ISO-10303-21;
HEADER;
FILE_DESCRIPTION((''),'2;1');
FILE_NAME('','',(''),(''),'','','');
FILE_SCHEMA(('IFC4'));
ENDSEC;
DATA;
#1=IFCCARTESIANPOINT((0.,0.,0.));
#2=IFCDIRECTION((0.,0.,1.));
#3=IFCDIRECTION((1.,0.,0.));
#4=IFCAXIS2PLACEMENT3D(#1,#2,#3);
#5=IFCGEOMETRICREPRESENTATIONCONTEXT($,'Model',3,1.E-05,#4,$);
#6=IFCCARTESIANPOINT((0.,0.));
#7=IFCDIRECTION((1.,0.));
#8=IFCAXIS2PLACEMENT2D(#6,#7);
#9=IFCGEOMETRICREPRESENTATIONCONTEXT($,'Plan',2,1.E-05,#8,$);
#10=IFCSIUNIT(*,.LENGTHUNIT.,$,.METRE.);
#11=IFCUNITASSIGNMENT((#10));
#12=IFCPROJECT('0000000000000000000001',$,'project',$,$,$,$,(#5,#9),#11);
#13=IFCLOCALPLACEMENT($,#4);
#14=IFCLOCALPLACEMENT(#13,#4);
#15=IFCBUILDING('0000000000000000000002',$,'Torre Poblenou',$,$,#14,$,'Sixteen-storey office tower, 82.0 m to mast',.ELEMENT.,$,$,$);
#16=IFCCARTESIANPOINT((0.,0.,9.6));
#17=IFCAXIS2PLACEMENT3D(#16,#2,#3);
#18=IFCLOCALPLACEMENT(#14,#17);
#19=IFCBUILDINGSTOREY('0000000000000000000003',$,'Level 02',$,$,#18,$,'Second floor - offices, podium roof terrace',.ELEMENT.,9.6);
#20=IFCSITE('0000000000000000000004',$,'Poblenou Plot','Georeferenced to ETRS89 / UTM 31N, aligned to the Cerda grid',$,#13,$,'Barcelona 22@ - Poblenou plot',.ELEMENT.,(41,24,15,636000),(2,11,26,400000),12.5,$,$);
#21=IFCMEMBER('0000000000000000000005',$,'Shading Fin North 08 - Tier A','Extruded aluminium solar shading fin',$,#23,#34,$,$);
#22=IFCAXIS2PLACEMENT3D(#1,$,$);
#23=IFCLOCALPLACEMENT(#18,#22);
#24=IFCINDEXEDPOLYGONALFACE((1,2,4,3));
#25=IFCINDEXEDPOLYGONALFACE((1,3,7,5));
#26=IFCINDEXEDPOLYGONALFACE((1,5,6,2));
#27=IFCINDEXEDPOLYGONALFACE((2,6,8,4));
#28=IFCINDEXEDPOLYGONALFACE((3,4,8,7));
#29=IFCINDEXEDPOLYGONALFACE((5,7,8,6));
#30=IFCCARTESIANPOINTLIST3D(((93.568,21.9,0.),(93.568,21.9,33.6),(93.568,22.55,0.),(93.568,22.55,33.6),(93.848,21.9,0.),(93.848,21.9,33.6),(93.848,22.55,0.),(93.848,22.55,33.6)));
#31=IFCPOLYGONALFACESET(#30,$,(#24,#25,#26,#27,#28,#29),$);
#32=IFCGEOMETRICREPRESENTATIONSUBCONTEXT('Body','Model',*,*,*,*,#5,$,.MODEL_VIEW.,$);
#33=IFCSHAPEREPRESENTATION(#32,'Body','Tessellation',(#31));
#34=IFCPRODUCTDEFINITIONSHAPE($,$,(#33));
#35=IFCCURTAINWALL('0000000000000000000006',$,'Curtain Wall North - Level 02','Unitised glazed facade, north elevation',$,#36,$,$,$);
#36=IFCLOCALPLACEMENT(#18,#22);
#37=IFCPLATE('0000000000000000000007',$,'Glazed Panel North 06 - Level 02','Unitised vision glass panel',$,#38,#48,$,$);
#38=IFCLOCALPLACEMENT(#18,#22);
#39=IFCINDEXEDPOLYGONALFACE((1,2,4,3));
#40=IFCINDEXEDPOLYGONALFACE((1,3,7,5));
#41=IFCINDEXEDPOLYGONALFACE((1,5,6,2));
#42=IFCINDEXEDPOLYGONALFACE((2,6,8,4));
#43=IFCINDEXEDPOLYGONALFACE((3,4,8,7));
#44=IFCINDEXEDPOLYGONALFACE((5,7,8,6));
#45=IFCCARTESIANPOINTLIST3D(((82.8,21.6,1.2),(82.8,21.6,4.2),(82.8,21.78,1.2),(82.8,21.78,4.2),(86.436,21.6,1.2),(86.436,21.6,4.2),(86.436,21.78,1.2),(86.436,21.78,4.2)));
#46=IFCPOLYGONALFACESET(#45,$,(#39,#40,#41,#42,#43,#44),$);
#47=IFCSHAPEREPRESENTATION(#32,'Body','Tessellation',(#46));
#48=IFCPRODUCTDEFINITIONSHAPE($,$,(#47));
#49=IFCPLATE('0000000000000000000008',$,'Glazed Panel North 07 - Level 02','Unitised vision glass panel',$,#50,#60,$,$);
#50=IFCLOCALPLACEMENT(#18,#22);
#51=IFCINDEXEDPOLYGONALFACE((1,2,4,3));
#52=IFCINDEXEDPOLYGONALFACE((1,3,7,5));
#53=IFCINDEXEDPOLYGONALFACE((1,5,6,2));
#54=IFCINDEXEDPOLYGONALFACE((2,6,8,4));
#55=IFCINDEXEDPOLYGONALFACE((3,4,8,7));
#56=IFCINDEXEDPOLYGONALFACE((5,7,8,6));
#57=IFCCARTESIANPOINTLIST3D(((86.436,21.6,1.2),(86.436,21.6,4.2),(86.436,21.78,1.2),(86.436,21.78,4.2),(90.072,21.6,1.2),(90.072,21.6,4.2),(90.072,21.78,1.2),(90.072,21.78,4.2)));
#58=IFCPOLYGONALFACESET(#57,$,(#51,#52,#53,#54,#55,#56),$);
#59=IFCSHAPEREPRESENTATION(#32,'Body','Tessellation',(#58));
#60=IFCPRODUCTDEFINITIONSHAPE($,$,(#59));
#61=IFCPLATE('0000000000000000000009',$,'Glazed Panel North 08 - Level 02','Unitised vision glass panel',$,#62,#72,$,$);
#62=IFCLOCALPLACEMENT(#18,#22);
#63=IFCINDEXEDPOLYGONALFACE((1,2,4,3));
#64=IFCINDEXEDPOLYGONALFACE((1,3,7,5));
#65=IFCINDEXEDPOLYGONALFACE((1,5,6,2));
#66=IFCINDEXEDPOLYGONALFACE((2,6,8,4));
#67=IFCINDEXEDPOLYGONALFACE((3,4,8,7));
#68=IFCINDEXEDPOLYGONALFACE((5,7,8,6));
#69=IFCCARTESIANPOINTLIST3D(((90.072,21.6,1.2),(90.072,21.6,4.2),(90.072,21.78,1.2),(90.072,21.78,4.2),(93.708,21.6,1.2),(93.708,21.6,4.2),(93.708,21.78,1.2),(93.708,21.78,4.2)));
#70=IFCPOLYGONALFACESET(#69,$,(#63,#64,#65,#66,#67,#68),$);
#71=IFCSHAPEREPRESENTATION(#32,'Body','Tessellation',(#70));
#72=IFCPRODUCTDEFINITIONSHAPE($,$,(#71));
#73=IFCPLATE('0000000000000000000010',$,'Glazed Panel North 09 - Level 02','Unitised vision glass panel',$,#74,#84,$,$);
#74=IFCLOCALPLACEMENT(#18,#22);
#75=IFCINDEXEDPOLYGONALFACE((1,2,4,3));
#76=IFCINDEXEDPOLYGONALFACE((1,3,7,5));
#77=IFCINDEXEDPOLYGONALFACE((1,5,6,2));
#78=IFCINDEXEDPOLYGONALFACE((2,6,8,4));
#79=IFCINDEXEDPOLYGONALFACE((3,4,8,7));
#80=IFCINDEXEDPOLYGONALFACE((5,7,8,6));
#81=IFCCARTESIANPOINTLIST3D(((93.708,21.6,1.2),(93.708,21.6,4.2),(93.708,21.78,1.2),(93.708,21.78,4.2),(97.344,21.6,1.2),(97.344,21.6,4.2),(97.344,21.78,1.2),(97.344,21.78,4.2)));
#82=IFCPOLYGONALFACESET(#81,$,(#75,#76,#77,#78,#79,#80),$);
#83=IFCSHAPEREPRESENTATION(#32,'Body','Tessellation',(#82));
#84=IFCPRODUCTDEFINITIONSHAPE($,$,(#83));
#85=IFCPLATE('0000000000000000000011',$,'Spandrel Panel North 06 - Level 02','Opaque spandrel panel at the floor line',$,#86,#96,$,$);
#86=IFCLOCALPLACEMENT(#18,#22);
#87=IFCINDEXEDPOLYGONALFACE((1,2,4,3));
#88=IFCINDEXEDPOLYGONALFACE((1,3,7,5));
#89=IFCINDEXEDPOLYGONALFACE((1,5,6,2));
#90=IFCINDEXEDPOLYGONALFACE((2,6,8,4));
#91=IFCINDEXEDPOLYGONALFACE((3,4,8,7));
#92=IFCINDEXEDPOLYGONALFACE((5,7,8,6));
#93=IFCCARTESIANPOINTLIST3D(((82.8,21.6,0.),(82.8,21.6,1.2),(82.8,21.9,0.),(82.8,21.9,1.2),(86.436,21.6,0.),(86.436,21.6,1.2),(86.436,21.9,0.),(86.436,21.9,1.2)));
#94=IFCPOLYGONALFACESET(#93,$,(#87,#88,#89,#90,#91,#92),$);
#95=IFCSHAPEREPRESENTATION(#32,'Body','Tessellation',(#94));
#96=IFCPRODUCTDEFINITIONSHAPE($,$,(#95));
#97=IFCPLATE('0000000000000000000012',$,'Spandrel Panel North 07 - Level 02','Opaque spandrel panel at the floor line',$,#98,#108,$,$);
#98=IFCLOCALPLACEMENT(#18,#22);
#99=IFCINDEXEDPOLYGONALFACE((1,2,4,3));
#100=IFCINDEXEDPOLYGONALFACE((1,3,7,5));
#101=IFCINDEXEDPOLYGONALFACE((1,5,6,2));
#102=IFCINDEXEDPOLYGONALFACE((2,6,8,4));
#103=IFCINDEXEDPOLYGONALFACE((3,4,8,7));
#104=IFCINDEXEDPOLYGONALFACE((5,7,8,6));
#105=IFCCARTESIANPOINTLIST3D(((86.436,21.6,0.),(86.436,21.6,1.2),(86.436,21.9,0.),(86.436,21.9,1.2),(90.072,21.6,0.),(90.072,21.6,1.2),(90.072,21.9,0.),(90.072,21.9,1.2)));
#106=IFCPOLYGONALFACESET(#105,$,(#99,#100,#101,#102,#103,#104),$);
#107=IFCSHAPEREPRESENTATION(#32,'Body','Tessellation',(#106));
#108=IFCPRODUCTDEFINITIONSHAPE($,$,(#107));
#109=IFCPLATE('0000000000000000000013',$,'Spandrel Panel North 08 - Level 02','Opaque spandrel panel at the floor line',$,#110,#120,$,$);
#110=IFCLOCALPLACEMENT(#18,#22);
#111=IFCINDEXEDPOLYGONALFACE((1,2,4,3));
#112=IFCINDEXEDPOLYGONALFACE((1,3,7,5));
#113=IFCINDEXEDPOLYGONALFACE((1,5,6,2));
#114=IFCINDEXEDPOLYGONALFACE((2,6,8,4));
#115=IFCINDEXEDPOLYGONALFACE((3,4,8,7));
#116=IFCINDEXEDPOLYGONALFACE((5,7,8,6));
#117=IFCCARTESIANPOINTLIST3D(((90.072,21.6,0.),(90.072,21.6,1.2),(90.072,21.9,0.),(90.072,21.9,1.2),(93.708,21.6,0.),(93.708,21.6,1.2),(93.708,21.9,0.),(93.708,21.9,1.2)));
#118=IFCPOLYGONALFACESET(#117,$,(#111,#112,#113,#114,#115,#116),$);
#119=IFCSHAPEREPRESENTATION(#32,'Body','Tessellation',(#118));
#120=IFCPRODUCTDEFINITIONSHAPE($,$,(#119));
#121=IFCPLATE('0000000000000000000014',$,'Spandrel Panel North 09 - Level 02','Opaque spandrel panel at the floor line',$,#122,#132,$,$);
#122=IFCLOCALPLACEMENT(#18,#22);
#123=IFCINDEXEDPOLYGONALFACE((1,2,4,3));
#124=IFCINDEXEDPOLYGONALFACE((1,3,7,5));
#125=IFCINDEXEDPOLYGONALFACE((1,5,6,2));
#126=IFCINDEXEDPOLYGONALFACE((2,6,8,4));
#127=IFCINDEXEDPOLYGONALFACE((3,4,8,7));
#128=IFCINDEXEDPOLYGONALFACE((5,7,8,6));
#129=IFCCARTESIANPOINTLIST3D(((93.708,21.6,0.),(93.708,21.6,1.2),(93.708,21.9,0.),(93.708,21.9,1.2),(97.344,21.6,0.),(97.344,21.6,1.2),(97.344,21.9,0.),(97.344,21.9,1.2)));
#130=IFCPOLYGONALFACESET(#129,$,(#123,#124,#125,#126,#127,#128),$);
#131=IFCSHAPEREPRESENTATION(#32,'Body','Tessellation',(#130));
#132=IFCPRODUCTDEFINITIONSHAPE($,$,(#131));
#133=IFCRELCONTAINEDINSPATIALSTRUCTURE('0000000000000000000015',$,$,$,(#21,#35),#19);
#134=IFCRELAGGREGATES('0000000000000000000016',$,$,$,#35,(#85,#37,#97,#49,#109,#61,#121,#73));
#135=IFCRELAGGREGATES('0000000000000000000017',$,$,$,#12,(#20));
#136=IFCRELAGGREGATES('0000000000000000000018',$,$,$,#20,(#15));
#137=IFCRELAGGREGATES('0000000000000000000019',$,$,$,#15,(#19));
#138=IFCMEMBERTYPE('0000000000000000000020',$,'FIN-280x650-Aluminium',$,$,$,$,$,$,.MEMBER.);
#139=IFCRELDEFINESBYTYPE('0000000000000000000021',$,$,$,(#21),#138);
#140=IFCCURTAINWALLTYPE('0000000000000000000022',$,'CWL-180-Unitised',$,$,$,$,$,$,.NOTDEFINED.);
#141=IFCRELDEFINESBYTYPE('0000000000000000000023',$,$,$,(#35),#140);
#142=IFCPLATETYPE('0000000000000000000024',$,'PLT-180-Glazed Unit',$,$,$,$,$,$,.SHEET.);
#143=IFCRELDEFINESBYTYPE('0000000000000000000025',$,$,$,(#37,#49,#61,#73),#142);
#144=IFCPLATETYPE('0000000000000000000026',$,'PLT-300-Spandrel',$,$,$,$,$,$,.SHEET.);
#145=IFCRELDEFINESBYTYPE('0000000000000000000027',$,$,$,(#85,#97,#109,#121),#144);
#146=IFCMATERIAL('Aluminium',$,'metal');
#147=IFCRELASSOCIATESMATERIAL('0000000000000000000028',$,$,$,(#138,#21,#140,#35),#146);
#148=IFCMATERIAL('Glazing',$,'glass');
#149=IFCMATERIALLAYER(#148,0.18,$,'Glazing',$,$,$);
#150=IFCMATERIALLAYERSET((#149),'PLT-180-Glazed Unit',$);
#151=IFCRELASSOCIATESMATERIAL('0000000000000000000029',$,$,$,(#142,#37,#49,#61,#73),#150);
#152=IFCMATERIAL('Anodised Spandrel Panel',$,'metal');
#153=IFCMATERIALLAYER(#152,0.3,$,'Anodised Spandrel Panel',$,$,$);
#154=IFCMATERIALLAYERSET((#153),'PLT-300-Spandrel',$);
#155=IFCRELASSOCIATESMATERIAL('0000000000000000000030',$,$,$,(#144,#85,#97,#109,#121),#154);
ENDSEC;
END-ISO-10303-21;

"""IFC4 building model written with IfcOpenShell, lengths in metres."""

from ifc_helpers import new_model, si_unit, frame, origin_with_axes, origin_2d_with_axis, place, context, subcontext, project, spatial, line, indexed_curve, rectangle, outline, extrude, material, layer, layer_set, layer_usage, material_profile, profile_set, profile_usage, type_object, element, aggregate, save


model = new_model("IFC4")

# Units and contexts
model_context = context("Model", 3, precision=1e-05, world=origin_with_axes())
plan_context = context("Plan", 2, precision=1e-05, world=origin_2d_with_axis())
body_context = subcontext(model_context, "Body", "Model", "MODEL_VIEW")
ifc_project = project(units=[si_unit("LENGTHUNIT", "METRE")], contexts=[model_context, plan_context])

# Site, building, storey
site_placement = place(None, origin_with_axes())
site = spatial("IfcSite", under=ifc_project, at=site_placement, Name="Poblenou Plot", Description="Georeferenced to ETRS89 / UTM 31N, aligned to the Cerda grid", LongName="Barcelona 22@ - Poblenou plot", CompositionType="ELEMENT", RefLatitude=(41, 24, 15, 636000), RefLongitude=(2, 11, 26, 400000), RefElevation=12.5)
building_placement = place(site_placement, origin_with_axes())
building = spatial("IfcBuilding", under=site, at=building_placement, Name="Torre Poblenou", LongName="Sixteen-storey office tower, 82.0 m to mast", CompositionType="ELEMENT")
storey_placement = place(building_placement, frame((0.0, 0.0, 9.6), z_axis=(0.0, 0.0, 1.0), x_axis=(1.0, 0.0, 0.0)))
storey = spatial("IfcBuildingStorey", under=building, at=storey_placement, Name="Level 02", LongName="Second floor - offices, podium roof terrace", CompositionType="ELEMENT", Elevation=9.6)

# Member
ifc_material_1 = material(Name="Aluminium", Category="metal")
ifc_material_profile_1 = material_profile(ifc_material_1, rectangle(XDim=0.28, YDim=0.65))
ifc_profile_set_1 = profile_set([ifc_material_profile_1], Name="FIN-280x650-Aluminium")
member_type = type_object("IfcMemberType", Name="FIN-280x650-Aluminium", PredefinedType="MEMBER", material=ifc_profile_set_1)
ifc_profile_usage_1 = profile_usage(ifc_profile_set_1)
member_1_placement = place(storey_placement, frame((93.568, 21.9, 0.0), z_axis=(0.0, 0.0, 1.0), x_axis=(1.0, 0.0, 0.0)))
element("IfcMember", 1, at=member_1_placement, inside=storey, type_object=member_type, material=ifc_profile_usage_1, Name="Shading Fin North 08 - Tier A", Description="Extruded aluminium solar shading fin", context=body_context, shape_type="SweptSolid", body=[
    extrude(outline(indexed_curve([(0.0, 0.0), (0.28, 0.0), (0.28, 0.65), (0.0, 0.65)], segments=[line(1, 2, 3, 4, 1)])), origin_with_axes(), (0.0, 0.0, 1.0), 33.6),
])

# Curtain wall, plates
curtain_wall_type = type_object("IfcCurtainWallType", Name="CWL-180-Unitised", PredefinedType="NOTDEFINED", material=ifc_material_1)
curtain_wall_placement = place(storey_placement, frame((64.62, 21.6, 0.0), z_axis=(0.0, 0.0, 1.0), x_axis=(1.0, 0.0, 0.0)))
curtain_wall = element("IfcCurtainWall", 2, at=curtain_wall_placement, inside=storey, type_object=curtain_wall_type, material=ifc_material_1, Name="Curtain Wall North - Level 02", Description="Unitised glazed facade, north elevation")
ifc_material_2 = material(Name="Glazing", Category="glass")
ifc_layer_1 = layer(ifc_material_2, 0.18, Name="Glazing")
ifc_layer_set_1 = layer_set([ifc_layer_1], Name="PLT-180-Glazed Unit")
ifc_layer_usage_1 = layer_usage(ifc_layer_set_1, "AXIS2", "POSITIVE", 0.0)
plate_type_1 = type_object("IfcPlateType", Name="PLT-180-Glazed Unit", PredefinedType="SHEET", material=ifc_layer_set_1)
plate_1_placement = place(curtain_wall_placement, frame((18.18, 0.0, 1.2), z_axis=(0.0, 0.0, 1.0), x_axis=(1.0, 0.0, 0.0)))
plate_1 = element("IfcPlate", 3, at=plate_1_placement, type_object=plate_type_1, material=ifc_layer_usage_1, Name="Glazed Panel North 06 - Level 02", Description="Unitised vision glass panel", context=body_context, shape_type="SweptSolid", body=[
    extrude(outline(indexed_curve([(0.0, 0.0), (3.636, 0.0), (3.636, 0.18), (0.0, 0.18)], segments=[line(1, 2, 3, 4, 1)])), origin_with_axes(), (0.0, 0.0, 1.0), 3.0),
])
ifc_layer_usage_2 = layer_usage(ifc_layer_set_1, "AXIS2", "POSITIVE", 0.0)
plate_2_placement = place(curtain_wall_placement, frame((21.816, 0.0, 1.2), z_axis=(0.0, 0.0, 1.0), x_axis=(1.0, 0.0, 0.0)))
plate_2 = element("IfcPlate", 4, at=plate_2_placement, type_object=plate_type_1, material=ifc_layer_usage_2, Name="Glazed Panel North 07 - Level 02", Description="Unitised vision glass panel", context=body_context, shape_type="SweptSolid", body=[
    extrude(outline(indexed_curve([(0.0, 0.0), (3.636, 0.0), (3.636, 0.18), (0.0, 0.18)], segments=[line(1, 2, 3, 4, 1)])), origin_with_axes(), (0.0, 0.0, 1.0), 3.0),
])
ifc_layer_usage_3 = layer_usage(ifc_layer_set_1, "AXIS2", "POSITIVE", 0.0)
plate_3_placement = place(curtain_wall_placement, frame((25.452, 0.0, 1.2), z_axis=(0.0, 0.0, 1.0), x_axis=(1.0, 0.0, 0.0)))
plate_3 = element("IfcPlate", 5, at=plate_3_placement, type_object=plate_type_1, material=ifc_layer_usage_3, Name="Glazed Panel North 08 - Level 02", Description="Unitised vision glass panel", context=body_context, shape_type="SweptSolid", body=[
    extrude(outline(indexed_curve([(0.0, 0.0), (3.636, 0.0), (3.636, 0.18), (0.0, 0.18)], segments=[line(1, 2, 3, 4, 1)])), origin_with_axes(), (0.0, 0.0, 1.0), 3.0),
])
ifc_layer_usage_4 = layer_usage(ifc_layer_set_1, "AXIS2", "POSITIVE", 0.0)
plate_4_placement = place(curtain_wall_placement, frame((29.088, 0.0, 1.2), z_axis=(0.0, 0.0, 1.0), x_axis=(1.0, 0.0, 0.0)))
plate_4 = element("IfcPlate", 6, at=plate_4_placement, type_object=plate_type_1, material=ifc_layer_usage_4, Name="Glazed Panel North 09 - Level 02", Description="Unitised vision glass panel", context=body_context, shape_type="SweptSolid", body=[
    extrude(outline(indexed_curve([(0.0, 0.0), (3.636, 0.0), (3.636, 0.18), (0.0, 0.18)], segments=[line(1, 2, 3, 4, 1)])), origin_with_axes(), (0.0, 0.0, 1.0), 3.0),
])
ifc_material_3 = material(Name="Anodised Spandrel Panel", Category="metal")
ifc_layer_2 = layer(ifc_material_3, 0.3, Name="Anodised Spandrel Panel")
ifc_layer_set_2 = layer_set([ifc_layer_2], Name="PLT-300-Spandrel")
ifc_layer_usage_5 = layer_usage(ifc_layer_set_2, "AXIS2", "POSITIVE", 0.0)
plate_type_2 = type_object("IfcPlateType", Name="PLT-300-Spandrel", PredefinedType="SHEET", material=ifc_layer_set_2)
plate_5_placement = place(curtain_wall_placement, frame((18.18, 0.0, 0.0), z_axis=(0.0, 0.0, 1.0), x_axis=(1.0, 0.0, 0.0)))
plate_5 = element("IfcPlate", 7, at=plate_5_placement, type_object=plate_type_2, material=ifc_layer_usage_5, Name="Spandrel Panel North 06 - Level 02", Description="Opaque spandrel panel at the floor line", context=body_context, shape_type="SweptSolid", body=[
    extrude(outline(indexed_curve([(0.0, 0.0), (3.636, 0.0), (3.636, 0.3), (0.0, 0.3)], segments=[line(1, 2, 3, 4, 1)])), origin_with_axes(), (0.0, 0.0, 1.0), 1.2),
])
ifc_layer_usage_6 = layer_usage(ifc_layer_set_2, "AXIS2", "POSITIVE", 0.0)
plate_6_placement = place(curtain_wall_placement, frame((21.816, 0.0, 0.0), z_axis=(0.0, 0.0, 1.0), x_axis=(1.0, 0.0, 0.0)))
plate_6 = element("IfcPlate", 8, at=plate_6_placement, type_object=plate_type_2, material=ifc_layer_usage_6, Name="Spandrel Panel North 07 - Level 02", Description="Opaque spandrel panel at the floor line", context=body_context, shape_type="SweptSolid", body=[
    extrude(outline(indexed_curve([(0.0, 0.0), (3.636, 0.0), (3.636, 0.3), (0.0, 0.3)], segments=[line(1, 2, 3, 4, 1)])), origin_with_axes(), (0.0, 0.0, 1.0), 1.2),
])
ifc_layer_usage_7 = layer_usage(ifc_layer_set_2, "AXIS2", "POSITIVE", 0.0)
plate_7_placement = place(curtain_wall_placement, frame((25.452, 0.0, 0.0), z_axis=(0.0, 0.0, 1.0), x_axis=(1.0, 0.0, 0.0)))
plate_7 = element("IfcPlate", 9, at=plate_7_placement, type_object=plate_type_2, material=ifc_layer_usage_7, Name="Spandrel Panel North 08 - Level 02", Description="Opaque spandrel panel at the floor line", context=body_context, shape_type="SweptSolid", body=[
    extrude(outline(indexed_curve([(0.0, 0.0), (3.636, 0.0), (3.636, 0.3), (0.0, 0.3)], segments=[line(1, 2, 3, 4, 1)])), origin_with_axes(), (0.0, 0.0, 1.0), 1.2),
])
ifc_layer_usage_8 = layer_usage(ifc_layer_set_2, "AXIS2", "POSITIVE", 0.0)
plate_8_placement = place(curtain_wall_placement, frame((29.088, 0.0, 0.0), z_axis=(0.0, 0.0, 1.0), x_axis=(1.0, 0.0, 0.0)))
plate_8 = element("IfcPlate", 10, at=plate_8_placement, type_object=plate_type_2, material=ifc_layer_usage_8, Name="Spandrel Panel North 09 - Level 02", Description="Opaque spandrel panel at the floor line", context=body_context, shape_type="SweptSolid", body=[
    extrude(outline(indexed_curve([(0.0, 0.0), (3.636, 0.0), (3.636, 0.3), (0.0, 0.3)], segments=[line(1, 2, 3, 4, 1)])), origin_with_axes(), (0.0, 0.0, 1.0), 1.2),
])
aggregate(curtain_wall, [plate_5, plate_1, plate_6, plate_2, plate_7, plate_3, plate_8, plate_4])

save(model, "model.ifc")
